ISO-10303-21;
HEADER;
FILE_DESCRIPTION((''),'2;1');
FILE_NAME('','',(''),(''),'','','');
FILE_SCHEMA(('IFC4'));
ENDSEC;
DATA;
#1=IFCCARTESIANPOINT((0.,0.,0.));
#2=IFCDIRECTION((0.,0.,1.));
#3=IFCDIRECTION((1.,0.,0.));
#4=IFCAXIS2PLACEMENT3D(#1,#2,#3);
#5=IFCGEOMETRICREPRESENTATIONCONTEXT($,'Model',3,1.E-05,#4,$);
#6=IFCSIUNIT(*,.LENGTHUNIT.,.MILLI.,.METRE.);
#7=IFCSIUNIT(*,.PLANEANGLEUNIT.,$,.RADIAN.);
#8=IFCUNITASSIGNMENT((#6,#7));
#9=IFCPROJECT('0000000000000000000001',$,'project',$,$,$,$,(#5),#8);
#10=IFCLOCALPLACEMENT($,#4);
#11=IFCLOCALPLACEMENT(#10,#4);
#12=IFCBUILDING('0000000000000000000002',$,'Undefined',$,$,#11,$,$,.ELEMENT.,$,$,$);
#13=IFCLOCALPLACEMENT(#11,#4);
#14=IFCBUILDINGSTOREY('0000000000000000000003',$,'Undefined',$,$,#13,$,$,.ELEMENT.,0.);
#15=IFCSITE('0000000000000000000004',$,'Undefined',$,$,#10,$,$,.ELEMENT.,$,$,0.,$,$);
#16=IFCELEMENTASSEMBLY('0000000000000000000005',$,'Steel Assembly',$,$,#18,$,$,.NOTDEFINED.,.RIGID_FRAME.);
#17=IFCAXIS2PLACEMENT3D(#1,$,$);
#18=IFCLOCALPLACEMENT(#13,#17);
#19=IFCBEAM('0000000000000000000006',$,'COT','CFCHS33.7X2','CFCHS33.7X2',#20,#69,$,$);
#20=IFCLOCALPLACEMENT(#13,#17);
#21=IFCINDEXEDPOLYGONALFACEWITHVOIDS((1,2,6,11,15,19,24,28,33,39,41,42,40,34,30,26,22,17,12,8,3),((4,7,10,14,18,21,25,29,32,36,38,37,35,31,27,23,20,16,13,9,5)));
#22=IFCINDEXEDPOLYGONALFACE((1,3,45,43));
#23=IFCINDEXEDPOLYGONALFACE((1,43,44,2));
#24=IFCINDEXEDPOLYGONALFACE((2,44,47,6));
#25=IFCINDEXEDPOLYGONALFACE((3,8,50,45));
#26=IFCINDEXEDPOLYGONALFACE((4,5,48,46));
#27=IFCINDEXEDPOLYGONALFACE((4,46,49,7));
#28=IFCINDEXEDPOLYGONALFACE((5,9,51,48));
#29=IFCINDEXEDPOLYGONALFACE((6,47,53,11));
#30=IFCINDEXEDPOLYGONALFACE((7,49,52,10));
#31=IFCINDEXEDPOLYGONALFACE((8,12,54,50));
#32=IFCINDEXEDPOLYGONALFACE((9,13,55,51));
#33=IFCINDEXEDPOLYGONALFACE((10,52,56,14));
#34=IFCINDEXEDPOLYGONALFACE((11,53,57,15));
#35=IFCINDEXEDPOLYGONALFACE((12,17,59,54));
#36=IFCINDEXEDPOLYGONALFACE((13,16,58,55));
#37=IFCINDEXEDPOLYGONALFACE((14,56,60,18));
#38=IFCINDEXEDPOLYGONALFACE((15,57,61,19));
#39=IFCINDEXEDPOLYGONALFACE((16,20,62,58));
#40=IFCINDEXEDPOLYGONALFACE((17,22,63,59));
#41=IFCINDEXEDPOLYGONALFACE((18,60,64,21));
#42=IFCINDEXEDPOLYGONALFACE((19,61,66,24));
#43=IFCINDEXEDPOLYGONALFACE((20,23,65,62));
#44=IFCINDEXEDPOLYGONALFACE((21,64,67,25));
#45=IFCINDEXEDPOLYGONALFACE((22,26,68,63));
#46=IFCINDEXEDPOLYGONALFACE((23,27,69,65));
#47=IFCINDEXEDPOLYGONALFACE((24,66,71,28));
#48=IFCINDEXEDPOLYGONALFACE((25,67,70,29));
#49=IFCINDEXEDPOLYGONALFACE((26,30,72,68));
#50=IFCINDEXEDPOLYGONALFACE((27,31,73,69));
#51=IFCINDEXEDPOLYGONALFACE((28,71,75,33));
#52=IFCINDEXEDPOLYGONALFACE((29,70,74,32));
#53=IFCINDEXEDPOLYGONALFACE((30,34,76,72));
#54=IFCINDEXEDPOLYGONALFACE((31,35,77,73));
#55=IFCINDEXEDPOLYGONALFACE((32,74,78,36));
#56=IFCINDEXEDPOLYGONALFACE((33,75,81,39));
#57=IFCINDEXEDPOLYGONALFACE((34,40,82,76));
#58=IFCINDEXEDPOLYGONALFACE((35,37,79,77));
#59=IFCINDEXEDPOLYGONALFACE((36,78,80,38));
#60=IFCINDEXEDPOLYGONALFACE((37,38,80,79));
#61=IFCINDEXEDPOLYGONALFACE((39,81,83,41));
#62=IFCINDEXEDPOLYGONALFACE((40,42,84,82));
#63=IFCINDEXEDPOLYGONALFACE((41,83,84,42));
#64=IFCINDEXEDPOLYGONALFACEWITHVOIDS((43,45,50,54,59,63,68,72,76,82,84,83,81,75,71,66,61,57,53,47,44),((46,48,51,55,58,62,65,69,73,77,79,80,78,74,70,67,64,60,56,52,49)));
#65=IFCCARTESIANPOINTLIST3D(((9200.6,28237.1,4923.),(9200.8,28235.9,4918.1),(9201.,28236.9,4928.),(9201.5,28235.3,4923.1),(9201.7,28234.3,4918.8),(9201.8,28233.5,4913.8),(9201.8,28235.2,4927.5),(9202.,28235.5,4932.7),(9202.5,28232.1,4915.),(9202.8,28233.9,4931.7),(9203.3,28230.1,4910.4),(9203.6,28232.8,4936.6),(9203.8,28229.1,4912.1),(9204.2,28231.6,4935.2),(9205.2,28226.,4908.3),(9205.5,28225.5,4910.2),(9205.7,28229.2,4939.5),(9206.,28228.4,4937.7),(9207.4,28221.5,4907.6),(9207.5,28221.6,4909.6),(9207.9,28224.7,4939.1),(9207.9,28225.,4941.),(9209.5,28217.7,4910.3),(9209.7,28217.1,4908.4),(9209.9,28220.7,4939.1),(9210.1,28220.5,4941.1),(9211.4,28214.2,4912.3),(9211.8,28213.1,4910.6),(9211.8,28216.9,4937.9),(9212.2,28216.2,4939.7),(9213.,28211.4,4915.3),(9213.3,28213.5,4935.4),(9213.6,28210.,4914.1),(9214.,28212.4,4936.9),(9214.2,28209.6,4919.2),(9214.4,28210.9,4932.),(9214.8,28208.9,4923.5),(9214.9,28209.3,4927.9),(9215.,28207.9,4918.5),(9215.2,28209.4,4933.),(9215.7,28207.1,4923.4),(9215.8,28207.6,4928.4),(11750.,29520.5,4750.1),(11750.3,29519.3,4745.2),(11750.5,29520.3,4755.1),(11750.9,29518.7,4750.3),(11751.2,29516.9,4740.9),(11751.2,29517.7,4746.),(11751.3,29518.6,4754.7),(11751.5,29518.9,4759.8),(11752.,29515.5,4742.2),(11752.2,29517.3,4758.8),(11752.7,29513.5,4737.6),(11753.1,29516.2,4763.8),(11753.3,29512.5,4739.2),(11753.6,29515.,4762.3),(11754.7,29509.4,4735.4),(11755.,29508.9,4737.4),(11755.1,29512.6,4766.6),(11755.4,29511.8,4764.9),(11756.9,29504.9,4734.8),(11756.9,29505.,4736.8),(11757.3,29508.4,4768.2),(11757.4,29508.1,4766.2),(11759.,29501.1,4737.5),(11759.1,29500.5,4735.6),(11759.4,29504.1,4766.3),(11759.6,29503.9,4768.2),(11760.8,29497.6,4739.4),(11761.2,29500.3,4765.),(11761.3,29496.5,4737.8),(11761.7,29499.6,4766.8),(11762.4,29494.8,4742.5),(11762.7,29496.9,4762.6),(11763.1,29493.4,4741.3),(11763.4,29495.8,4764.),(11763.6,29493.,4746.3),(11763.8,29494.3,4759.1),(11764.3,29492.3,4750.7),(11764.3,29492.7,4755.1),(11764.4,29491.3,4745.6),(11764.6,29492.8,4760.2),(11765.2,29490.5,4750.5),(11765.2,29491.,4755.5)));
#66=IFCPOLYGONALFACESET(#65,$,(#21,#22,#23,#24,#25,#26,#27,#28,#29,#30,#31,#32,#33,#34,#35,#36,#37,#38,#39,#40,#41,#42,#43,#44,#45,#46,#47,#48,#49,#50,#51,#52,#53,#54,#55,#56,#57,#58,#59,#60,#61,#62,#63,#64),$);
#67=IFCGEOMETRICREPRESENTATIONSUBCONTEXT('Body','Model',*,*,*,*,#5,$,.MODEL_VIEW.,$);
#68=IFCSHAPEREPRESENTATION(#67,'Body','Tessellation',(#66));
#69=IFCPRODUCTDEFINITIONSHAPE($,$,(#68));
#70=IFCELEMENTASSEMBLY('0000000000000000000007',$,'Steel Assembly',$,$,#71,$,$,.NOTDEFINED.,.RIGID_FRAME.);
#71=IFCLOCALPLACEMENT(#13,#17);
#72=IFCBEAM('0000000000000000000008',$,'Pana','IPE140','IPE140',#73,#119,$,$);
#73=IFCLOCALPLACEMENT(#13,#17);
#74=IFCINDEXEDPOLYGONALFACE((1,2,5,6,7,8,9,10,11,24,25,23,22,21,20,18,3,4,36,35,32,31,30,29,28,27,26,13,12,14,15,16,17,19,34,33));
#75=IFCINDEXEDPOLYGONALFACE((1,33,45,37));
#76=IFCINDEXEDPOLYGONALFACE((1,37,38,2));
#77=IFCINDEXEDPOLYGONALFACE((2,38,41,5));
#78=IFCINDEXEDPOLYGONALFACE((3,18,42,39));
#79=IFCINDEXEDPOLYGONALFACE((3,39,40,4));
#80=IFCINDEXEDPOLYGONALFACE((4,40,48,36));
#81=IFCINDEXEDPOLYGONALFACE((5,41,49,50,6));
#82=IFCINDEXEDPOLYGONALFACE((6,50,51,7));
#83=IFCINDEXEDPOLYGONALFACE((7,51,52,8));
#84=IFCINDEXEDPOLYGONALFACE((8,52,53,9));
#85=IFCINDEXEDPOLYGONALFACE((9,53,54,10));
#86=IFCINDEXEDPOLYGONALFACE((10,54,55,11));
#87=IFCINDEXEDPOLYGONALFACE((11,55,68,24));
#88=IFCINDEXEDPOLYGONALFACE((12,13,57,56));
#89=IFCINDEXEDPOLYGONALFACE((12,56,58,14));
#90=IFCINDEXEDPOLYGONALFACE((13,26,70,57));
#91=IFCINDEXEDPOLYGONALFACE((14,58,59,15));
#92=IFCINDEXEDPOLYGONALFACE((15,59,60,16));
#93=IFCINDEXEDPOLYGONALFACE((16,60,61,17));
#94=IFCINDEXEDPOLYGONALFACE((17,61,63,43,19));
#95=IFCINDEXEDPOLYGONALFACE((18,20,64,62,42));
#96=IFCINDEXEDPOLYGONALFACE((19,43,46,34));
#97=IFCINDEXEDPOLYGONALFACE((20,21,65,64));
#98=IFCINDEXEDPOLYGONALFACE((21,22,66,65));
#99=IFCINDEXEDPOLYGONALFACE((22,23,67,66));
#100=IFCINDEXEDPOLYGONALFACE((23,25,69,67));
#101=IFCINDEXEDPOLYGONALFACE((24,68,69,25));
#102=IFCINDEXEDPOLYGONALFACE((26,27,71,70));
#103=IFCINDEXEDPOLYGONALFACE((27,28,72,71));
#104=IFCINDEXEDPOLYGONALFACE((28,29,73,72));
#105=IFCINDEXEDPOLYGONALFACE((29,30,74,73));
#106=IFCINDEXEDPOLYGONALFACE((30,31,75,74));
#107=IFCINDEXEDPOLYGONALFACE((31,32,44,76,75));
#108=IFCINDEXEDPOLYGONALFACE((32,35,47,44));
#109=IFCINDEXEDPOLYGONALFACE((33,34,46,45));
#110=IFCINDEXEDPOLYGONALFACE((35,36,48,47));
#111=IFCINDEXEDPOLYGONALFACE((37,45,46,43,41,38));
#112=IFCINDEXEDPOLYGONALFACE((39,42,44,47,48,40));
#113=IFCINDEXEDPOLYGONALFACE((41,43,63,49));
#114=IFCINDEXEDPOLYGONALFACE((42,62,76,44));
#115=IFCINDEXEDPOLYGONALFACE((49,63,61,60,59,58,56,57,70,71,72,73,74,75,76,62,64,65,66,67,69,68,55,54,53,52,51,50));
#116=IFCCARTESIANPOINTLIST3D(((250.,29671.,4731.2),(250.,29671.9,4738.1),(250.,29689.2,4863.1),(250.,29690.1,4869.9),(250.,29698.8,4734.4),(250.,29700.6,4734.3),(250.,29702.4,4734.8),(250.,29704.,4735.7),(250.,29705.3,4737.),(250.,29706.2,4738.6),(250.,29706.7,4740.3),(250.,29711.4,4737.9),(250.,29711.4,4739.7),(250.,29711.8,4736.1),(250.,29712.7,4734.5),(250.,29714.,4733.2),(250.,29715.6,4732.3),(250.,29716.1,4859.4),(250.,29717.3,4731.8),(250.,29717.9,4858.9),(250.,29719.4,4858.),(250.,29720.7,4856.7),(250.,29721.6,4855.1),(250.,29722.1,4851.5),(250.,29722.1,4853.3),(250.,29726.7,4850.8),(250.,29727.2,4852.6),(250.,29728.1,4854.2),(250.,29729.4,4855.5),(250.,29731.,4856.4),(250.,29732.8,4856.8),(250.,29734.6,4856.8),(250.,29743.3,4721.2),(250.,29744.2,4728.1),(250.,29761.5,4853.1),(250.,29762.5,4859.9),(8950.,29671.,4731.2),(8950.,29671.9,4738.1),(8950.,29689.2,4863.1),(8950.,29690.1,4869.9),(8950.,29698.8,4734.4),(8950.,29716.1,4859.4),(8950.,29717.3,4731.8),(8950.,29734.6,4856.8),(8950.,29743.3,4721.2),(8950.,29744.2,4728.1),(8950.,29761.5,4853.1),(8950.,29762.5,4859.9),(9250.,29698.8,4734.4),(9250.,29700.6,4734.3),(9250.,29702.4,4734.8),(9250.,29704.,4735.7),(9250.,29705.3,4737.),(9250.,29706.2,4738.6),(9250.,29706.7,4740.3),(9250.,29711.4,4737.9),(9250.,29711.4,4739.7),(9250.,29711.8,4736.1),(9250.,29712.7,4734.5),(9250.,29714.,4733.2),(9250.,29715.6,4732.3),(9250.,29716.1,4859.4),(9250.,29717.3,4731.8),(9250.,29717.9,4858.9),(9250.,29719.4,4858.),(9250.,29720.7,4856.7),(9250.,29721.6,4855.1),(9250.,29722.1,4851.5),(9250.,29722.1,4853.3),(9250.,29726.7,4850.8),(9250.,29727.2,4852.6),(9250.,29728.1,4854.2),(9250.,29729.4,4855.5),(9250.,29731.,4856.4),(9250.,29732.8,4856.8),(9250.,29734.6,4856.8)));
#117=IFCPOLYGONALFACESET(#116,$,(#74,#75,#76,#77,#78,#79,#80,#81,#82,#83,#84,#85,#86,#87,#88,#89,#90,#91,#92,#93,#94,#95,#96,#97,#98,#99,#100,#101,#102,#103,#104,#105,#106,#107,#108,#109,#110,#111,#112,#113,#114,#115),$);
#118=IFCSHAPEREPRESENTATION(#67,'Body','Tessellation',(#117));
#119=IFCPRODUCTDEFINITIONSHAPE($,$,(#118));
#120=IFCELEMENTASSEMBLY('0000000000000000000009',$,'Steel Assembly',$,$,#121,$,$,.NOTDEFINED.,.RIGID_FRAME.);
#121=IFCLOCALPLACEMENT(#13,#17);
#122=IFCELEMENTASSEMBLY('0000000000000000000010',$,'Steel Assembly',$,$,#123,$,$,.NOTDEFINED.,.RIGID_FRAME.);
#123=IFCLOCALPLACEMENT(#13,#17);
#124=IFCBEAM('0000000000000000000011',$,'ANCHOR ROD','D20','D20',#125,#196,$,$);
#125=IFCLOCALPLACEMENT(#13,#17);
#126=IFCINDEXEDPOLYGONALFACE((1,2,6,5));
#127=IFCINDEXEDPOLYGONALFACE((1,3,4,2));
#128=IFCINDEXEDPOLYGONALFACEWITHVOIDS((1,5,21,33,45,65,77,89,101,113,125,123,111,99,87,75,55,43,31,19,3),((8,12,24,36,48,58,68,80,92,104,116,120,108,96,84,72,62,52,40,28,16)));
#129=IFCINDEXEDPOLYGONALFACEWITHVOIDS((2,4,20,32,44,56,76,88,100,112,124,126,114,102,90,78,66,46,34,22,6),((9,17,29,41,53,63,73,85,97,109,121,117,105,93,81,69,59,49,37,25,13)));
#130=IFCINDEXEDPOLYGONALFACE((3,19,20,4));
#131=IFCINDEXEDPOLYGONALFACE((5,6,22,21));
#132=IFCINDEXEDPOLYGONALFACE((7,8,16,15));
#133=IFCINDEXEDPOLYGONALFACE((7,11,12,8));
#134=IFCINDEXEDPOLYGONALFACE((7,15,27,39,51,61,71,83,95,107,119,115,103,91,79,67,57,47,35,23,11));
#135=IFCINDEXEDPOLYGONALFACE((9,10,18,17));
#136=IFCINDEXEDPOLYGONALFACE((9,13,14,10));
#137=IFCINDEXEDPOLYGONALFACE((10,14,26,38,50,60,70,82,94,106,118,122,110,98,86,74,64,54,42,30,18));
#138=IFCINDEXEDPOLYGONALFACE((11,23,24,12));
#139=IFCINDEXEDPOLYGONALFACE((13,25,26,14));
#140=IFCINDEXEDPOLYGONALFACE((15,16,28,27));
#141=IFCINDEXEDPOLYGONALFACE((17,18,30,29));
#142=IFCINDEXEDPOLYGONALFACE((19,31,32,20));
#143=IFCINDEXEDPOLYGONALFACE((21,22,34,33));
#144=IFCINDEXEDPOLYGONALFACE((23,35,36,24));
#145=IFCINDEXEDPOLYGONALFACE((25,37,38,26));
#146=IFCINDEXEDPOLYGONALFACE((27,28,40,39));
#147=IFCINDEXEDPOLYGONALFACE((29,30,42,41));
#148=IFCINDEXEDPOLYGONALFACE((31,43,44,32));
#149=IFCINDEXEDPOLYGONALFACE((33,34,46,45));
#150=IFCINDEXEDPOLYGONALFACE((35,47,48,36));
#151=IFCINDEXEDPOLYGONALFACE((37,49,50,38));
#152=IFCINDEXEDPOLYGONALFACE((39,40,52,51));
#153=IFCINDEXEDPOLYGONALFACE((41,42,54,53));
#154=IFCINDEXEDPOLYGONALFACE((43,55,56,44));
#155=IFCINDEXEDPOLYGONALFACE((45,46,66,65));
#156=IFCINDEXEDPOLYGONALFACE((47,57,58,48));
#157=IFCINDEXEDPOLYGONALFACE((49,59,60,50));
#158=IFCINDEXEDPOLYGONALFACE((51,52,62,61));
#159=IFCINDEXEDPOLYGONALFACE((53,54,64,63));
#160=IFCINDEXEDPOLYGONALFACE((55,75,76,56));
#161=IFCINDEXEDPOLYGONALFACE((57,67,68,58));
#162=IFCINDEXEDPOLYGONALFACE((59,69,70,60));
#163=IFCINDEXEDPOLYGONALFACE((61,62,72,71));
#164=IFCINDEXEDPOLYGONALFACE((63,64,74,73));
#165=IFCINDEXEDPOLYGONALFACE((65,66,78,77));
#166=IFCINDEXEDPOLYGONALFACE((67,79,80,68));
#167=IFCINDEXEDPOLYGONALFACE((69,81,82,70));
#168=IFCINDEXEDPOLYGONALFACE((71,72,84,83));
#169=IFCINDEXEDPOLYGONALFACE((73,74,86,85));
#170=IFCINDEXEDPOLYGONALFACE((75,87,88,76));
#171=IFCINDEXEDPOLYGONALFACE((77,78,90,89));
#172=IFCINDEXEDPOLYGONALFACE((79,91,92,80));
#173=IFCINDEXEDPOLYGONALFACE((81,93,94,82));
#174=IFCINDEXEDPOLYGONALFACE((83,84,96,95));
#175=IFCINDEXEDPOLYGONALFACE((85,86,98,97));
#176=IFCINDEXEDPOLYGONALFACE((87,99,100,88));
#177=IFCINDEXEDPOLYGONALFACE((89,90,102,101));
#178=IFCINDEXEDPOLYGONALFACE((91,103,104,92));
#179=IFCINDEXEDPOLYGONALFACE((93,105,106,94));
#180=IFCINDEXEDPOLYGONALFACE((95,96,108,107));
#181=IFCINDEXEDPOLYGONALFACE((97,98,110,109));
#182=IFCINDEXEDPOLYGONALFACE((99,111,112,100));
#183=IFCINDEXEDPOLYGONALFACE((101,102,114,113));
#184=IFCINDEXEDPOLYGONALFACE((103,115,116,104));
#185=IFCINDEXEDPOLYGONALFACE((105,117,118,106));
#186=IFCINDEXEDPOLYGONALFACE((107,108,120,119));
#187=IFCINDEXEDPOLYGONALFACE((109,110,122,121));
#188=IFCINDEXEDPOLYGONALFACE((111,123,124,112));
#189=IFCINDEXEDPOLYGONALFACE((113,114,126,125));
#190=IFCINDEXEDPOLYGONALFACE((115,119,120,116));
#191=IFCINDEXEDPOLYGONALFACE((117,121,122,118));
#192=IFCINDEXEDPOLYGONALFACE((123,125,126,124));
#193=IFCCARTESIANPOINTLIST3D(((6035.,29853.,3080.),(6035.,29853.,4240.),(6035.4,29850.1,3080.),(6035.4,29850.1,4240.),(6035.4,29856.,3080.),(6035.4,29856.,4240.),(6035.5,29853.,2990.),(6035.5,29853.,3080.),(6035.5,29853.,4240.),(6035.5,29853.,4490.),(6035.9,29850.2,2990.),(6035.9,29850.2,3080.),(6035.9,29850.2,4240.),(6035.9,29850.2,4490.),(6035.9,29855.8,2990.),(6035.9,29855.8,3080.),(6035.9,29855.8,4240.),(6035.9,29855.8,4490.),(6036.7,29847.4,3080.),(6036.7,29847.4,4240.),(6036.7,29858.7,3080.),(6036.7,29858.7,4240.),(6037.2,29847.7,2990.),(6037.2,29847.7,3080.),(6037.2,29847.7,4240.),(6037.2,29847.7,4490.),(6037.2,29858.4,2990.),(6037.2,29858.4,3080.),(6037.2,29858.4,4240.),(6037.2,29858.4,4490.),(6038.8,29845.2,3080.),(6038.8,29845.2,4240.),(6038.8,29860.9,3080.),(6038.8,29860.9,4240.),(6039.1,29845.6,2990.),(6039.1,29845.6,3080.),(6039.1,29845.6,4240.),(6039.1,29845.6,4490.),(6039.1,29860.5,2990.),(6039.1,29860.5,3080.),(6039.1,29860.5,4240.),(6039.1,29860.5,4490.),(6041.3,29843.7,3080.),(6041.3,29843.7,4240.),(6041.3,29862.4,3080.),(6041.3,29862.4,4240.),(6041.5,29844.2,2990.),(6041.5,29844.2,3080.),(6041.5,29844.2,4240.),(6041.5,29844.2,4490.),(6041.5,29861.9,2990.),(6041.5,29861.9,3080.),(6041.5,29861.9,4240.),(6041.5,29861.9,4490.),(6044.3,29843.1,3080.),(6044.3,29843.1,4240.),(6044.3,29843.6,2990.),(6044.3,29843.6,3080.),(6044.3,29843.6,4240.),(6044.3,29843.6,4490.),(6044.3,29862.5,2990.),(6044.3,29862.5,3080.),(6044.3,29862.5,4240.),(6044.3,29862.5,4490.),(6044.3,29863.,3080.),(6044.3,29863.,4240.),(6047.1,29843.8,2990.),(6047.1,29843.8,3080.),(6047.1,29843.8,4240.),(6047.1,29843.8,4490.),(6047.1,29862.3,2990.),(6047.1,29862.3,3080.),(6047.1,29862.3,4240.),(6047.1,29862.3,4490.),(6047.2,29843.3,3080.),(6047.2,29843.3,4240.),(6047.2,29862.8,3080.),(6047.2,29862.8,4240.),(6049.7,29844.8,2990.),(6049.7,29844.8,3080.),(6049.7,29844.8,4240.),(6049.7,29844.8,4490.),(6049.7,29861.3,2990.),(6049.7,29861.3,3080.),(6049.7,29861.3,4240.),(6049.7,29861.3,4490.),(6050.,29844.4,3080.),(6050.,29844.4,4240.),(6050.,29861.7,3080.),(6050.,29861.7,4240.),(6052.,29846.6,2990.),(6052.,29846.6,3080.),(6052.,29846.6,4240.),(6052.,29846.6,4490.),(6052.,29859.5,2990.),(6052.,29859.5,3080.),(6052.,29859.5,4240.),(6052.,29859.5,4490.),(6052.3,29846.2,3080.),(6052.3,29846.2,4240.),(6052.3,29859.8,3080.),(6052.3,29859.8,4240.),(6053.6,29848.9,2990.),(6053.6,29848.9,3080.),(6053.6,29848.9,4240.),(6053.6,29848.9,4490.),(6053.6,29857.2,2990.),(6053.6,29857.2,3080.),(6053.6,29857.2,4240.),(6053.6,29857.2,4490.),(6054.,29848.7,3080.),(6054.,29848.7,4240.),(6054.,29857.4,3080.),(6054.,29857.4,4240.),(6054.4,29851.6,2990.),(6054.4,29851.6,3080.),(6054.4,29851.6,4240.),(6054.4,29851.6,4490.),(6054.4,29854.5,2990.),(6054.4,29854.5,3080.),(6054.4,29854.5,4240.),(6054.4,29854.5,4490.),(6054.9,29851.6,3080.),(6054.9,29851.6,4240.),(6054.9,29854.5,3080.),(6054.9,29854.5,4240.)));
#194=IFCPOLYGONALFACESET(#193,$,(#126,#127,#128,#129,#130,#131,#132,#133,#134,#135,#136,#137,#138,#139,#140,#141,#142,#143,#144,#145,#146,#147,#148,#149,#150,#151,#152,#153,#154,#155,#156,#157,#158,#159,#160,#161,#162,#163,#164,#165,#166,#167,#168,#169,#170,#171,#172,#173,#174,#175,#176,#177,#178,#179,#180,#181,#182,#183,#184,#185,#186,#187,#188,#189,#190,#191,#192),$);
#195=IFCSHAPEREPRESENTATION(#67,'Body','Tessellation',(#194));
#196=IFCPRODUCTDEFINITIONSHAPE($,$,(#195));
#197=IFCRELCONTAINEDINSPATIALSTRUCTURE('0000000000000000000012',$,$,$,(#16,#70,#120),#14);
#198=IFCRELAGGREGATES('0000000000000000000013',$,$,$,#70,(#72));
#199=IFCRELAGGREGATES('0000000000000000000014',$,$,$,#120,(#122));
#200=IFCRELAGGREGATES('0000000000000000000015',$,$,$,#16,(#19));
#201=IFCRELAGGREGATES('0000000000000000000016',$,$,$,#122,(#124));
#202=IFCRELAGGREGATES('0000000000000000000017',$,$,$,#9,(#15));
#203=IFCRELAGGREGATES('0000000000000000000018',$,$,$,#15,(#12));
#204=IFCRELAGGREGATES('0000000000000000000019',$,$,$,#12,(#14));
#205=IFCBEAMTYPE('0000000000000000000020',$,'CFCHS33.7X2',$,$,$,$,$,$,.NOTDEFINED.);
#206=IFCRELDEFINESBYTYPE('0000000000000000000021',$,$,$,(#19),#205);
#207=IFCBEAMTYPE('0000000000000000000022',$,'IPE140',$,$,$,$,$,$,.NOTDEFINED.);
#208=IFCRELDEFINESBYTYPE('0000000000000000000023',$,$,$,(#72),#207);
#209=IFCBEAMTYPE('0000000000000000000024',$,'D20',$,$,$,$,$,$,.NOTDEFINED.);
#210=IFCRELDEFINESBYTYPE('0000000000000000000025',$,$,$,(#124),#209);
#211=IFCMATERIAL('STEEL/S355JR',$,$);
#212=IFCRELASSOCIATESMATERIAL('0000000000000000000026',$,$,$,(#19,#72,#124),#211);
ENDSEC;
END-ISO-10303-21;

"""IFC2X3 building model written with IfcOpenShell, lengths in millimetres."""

from ifc_helpers import new_model, si_unit, frame, origin_with_axes, origin_2d_with_axis, place, context, subcontext, project, spatial, polyline, circle, hollow_circle, i_section, outline, extrude, boolean, halfspace, material, type_object, element, aggregate, save


model = new_model("IFC2X3")

# Units and contexts
model_context = context("Model", 3, precision=1e-05, world=origin_with_axes())
body_context = subcontext(model_context, "Body", "Model", "MODEL_VIEW")
ifc_project = project(units=[si_unit("LENGTHUNIT", "METRE", prefix="MILLI"), si_unit("PLANEANGLEUNIT", "RADIAN")], contexts=[model_context])

# Site, building, storey
site_placement = place(None, origin_with_axes())
site = spatial("IfcSite", under=ifc_project, at=site_placement, Name="Undefined", CompositionType="ELEMENT", RefElevation=0.0)
building_placement = place(site_placement, origin_with_axes())
building = spatial("IfcBuilding", under=site, at=building_placement, Name="Undefined", CompositionType="ELEMENT")
storey_placement = place(building_placement, origin_with_axes())
storey = spatial("IfcBuildingStorey", under=building, at=storey_placement, Name="Undefined", CompositionType="ELEMENT", Elevation=0.0)

# Element assemblies, beams
assembly_1_placement = place(storey_placement, origin_with_axes())
assembly_1 = element("IfcElementAssembly", 1, at=assembly_1_placement, inside=storey, Name="Steel Assembly", AssemblyPlace="NOTDEFINED", PredefinedType="RIGID_FRAME")
ifc_material_1 = material(Name="STEEL/S355JR")
beam_type_1 = type_object("IfcBeamType", Name="CFCHS33.7X2", PredefinedType="NOTDEFINED")
beam_1_placement = place(assembly_1_placement, frame((9208.2, 28222.1, 4924.4), z_axis=(-0.438014, 0.888518, 0.136676), x_axis=(0.891576, 0.44882, -0.060446)))
beam_1 = element("IfcBeam", 2, at=beam_1_placement, type_object=beam_type_1, material=ifc_material_1, Name="COT", Description="CFCHS33.7X2", ObjectType="CFCHS33.7X2", context=body_context, shape_type="SweptSolid", body=[
    extrude(hollow_circle(Radius=16.9, WallThickness=2.0, at=origin_2d_with_axis()), frame((2859.5, 0.0, 0.0), z_axis=(-1.0, 0.0, 0.0), x_axis=(0.0, -1.0, 0.0)), (0.0, 0.0, 1.0), 2859.5),
])
beam_type_2 = type_object("IfcBeamType", Name="IPE140", PredefinedType="NOTDEFINED")
assembly_2_placement = place(storey_placement, origin_with_axes())
assembly_2 = element("IfcElementAssembly", 3, at=assembly_2_placement, inside=storey, Name="Steel Assembly", AssemblyPlace="NOTDEFINED", PredefinedType="RIGID_FRAME")
beam_2_placement = place(assembly_2_placement, frame((9250.0, 29716.7, 4795.6), z_axis=(0.0, 0.136926, 0.990581), x_axis=(-1.0, 0.0, 0.0)))
beam_2 = element("IfcBeam", 4, at=beam_2_placement, type_object=beam_type_2, material=ifc_material_1, Name="Pana", Description="IPE140", ObjectType="IPE140", context=body_context, shape_type="CSG", body=[
    boolean("DIFFERENCE", boolean("DIFFERENCE", extrude(i_section(OverallWidth=73.0, OverallDepth=140.0, WebThickness=4.7, FlangeThickness=6.9, FilletRadius=7.0, at=origin_2d_with_axis()), frame((9000.0, 0.0, 0.0), z_axis=(-1.0, 0.0, 0.0), x_axis=(0.0, -1.0, 0.0)), (0.0, 0.0, 1.0), 9005.0), extrude(outline(polyline([(0.0, 0.0), (11.9, 0.0), (11.9, 300.0), (138.1, 300.0), (138.1, 0.0), (150.0, 0.0), (150.0, 305.0), (0.0, 305.0), (0.0, 0.0)])), frame((300.0, -41.5, 75.0), z_axis=(0.0, 1.0, 0.0), x_axis=(0.0, 0.0, -1.0)), (0.0, 0.0, 1.0), 83.0)), halfspace(frame((-5.0, 0.0, 1070.0), z_axis=(1.0, 0.0, 0.0), x_axis=(0.0, 0.0, -1.0)), True)),
])
aggregate(assembly_2, [beam_2])

# Element assemblies, beam
assembly_3_placement = place(storey_placement, origin_with_axes())
assembly_3 = element("IfcElementAssembly", 5, at=assembly_3_placement, inside=storey, Name="Steel Assembly", AssemblyPlace="NOTDEFINED", PredefinedType="RIGID_FRAME")
assembly_4_placement = place(assembly_3_placement, origin_with_axes())
assembly_4 = element("IfcElementAssembly", 6, at=assembly_4_placement, Name="Steel Assembly", AssemblyPlace="NOTDEFINED", PredefinedType="RIGID_FRAME")
aggregate(assembly_3, [assembly_4])
beam_type_3 = type_object("IfcBeamType", Name="D20", PredefinedType="NOTDEFINED")
beam_3_placement = place(assembly_4_placement, frame((6045.0, 29853.0, 4240.0), z_axis=(0.0, -1.0, 0.0), x_axis=(0.0, 0.0, -1.0)))
beam_3 = element("IfcBeam", 7, at=beam_3_placement, type_object=beam_type_3, material=ifc_material_1, Name="ANCHOR ROD", Description="D20", ObjectType="D20", context=body_context, shape_type="CSG", body=[
    boolean("UNION", boolean("UNION", extrude(circle(Radius=10.0, at=origin_2d_with_axis()), frame((1160.0, 0.0, 0.0), z_axis=(-1.0, 0.0, 0.0), x_axis=(0.0, -1.0, 0.0)), (0.0, 0.0, 1.0), 1160.0), extrude(circle(Radius=9.5, at=origin_2d_with_axis()), frame((1250.0, 0.0, 0.0), z_axis=(-1.0, 0.0, 0.0), x_axis=(0.0, -1.0, 0.0)), (0.0, 0.0, 1.0), 90.0)), extrude(circle(Radius=9.5, at=origin_2d_with_axis()), frame((0.0, 0.0, 0.0), z_axis=(-1.0, 0.0, 0.0), x_axis=(0.0, -1.0, 0.0)), (0.0, 0.0, 1.0), 250.0)),
])

aggregate(assembly_1, [beam_1])

aggregate(assembly_4, [beam_3])

save(model, "model.ifc")
